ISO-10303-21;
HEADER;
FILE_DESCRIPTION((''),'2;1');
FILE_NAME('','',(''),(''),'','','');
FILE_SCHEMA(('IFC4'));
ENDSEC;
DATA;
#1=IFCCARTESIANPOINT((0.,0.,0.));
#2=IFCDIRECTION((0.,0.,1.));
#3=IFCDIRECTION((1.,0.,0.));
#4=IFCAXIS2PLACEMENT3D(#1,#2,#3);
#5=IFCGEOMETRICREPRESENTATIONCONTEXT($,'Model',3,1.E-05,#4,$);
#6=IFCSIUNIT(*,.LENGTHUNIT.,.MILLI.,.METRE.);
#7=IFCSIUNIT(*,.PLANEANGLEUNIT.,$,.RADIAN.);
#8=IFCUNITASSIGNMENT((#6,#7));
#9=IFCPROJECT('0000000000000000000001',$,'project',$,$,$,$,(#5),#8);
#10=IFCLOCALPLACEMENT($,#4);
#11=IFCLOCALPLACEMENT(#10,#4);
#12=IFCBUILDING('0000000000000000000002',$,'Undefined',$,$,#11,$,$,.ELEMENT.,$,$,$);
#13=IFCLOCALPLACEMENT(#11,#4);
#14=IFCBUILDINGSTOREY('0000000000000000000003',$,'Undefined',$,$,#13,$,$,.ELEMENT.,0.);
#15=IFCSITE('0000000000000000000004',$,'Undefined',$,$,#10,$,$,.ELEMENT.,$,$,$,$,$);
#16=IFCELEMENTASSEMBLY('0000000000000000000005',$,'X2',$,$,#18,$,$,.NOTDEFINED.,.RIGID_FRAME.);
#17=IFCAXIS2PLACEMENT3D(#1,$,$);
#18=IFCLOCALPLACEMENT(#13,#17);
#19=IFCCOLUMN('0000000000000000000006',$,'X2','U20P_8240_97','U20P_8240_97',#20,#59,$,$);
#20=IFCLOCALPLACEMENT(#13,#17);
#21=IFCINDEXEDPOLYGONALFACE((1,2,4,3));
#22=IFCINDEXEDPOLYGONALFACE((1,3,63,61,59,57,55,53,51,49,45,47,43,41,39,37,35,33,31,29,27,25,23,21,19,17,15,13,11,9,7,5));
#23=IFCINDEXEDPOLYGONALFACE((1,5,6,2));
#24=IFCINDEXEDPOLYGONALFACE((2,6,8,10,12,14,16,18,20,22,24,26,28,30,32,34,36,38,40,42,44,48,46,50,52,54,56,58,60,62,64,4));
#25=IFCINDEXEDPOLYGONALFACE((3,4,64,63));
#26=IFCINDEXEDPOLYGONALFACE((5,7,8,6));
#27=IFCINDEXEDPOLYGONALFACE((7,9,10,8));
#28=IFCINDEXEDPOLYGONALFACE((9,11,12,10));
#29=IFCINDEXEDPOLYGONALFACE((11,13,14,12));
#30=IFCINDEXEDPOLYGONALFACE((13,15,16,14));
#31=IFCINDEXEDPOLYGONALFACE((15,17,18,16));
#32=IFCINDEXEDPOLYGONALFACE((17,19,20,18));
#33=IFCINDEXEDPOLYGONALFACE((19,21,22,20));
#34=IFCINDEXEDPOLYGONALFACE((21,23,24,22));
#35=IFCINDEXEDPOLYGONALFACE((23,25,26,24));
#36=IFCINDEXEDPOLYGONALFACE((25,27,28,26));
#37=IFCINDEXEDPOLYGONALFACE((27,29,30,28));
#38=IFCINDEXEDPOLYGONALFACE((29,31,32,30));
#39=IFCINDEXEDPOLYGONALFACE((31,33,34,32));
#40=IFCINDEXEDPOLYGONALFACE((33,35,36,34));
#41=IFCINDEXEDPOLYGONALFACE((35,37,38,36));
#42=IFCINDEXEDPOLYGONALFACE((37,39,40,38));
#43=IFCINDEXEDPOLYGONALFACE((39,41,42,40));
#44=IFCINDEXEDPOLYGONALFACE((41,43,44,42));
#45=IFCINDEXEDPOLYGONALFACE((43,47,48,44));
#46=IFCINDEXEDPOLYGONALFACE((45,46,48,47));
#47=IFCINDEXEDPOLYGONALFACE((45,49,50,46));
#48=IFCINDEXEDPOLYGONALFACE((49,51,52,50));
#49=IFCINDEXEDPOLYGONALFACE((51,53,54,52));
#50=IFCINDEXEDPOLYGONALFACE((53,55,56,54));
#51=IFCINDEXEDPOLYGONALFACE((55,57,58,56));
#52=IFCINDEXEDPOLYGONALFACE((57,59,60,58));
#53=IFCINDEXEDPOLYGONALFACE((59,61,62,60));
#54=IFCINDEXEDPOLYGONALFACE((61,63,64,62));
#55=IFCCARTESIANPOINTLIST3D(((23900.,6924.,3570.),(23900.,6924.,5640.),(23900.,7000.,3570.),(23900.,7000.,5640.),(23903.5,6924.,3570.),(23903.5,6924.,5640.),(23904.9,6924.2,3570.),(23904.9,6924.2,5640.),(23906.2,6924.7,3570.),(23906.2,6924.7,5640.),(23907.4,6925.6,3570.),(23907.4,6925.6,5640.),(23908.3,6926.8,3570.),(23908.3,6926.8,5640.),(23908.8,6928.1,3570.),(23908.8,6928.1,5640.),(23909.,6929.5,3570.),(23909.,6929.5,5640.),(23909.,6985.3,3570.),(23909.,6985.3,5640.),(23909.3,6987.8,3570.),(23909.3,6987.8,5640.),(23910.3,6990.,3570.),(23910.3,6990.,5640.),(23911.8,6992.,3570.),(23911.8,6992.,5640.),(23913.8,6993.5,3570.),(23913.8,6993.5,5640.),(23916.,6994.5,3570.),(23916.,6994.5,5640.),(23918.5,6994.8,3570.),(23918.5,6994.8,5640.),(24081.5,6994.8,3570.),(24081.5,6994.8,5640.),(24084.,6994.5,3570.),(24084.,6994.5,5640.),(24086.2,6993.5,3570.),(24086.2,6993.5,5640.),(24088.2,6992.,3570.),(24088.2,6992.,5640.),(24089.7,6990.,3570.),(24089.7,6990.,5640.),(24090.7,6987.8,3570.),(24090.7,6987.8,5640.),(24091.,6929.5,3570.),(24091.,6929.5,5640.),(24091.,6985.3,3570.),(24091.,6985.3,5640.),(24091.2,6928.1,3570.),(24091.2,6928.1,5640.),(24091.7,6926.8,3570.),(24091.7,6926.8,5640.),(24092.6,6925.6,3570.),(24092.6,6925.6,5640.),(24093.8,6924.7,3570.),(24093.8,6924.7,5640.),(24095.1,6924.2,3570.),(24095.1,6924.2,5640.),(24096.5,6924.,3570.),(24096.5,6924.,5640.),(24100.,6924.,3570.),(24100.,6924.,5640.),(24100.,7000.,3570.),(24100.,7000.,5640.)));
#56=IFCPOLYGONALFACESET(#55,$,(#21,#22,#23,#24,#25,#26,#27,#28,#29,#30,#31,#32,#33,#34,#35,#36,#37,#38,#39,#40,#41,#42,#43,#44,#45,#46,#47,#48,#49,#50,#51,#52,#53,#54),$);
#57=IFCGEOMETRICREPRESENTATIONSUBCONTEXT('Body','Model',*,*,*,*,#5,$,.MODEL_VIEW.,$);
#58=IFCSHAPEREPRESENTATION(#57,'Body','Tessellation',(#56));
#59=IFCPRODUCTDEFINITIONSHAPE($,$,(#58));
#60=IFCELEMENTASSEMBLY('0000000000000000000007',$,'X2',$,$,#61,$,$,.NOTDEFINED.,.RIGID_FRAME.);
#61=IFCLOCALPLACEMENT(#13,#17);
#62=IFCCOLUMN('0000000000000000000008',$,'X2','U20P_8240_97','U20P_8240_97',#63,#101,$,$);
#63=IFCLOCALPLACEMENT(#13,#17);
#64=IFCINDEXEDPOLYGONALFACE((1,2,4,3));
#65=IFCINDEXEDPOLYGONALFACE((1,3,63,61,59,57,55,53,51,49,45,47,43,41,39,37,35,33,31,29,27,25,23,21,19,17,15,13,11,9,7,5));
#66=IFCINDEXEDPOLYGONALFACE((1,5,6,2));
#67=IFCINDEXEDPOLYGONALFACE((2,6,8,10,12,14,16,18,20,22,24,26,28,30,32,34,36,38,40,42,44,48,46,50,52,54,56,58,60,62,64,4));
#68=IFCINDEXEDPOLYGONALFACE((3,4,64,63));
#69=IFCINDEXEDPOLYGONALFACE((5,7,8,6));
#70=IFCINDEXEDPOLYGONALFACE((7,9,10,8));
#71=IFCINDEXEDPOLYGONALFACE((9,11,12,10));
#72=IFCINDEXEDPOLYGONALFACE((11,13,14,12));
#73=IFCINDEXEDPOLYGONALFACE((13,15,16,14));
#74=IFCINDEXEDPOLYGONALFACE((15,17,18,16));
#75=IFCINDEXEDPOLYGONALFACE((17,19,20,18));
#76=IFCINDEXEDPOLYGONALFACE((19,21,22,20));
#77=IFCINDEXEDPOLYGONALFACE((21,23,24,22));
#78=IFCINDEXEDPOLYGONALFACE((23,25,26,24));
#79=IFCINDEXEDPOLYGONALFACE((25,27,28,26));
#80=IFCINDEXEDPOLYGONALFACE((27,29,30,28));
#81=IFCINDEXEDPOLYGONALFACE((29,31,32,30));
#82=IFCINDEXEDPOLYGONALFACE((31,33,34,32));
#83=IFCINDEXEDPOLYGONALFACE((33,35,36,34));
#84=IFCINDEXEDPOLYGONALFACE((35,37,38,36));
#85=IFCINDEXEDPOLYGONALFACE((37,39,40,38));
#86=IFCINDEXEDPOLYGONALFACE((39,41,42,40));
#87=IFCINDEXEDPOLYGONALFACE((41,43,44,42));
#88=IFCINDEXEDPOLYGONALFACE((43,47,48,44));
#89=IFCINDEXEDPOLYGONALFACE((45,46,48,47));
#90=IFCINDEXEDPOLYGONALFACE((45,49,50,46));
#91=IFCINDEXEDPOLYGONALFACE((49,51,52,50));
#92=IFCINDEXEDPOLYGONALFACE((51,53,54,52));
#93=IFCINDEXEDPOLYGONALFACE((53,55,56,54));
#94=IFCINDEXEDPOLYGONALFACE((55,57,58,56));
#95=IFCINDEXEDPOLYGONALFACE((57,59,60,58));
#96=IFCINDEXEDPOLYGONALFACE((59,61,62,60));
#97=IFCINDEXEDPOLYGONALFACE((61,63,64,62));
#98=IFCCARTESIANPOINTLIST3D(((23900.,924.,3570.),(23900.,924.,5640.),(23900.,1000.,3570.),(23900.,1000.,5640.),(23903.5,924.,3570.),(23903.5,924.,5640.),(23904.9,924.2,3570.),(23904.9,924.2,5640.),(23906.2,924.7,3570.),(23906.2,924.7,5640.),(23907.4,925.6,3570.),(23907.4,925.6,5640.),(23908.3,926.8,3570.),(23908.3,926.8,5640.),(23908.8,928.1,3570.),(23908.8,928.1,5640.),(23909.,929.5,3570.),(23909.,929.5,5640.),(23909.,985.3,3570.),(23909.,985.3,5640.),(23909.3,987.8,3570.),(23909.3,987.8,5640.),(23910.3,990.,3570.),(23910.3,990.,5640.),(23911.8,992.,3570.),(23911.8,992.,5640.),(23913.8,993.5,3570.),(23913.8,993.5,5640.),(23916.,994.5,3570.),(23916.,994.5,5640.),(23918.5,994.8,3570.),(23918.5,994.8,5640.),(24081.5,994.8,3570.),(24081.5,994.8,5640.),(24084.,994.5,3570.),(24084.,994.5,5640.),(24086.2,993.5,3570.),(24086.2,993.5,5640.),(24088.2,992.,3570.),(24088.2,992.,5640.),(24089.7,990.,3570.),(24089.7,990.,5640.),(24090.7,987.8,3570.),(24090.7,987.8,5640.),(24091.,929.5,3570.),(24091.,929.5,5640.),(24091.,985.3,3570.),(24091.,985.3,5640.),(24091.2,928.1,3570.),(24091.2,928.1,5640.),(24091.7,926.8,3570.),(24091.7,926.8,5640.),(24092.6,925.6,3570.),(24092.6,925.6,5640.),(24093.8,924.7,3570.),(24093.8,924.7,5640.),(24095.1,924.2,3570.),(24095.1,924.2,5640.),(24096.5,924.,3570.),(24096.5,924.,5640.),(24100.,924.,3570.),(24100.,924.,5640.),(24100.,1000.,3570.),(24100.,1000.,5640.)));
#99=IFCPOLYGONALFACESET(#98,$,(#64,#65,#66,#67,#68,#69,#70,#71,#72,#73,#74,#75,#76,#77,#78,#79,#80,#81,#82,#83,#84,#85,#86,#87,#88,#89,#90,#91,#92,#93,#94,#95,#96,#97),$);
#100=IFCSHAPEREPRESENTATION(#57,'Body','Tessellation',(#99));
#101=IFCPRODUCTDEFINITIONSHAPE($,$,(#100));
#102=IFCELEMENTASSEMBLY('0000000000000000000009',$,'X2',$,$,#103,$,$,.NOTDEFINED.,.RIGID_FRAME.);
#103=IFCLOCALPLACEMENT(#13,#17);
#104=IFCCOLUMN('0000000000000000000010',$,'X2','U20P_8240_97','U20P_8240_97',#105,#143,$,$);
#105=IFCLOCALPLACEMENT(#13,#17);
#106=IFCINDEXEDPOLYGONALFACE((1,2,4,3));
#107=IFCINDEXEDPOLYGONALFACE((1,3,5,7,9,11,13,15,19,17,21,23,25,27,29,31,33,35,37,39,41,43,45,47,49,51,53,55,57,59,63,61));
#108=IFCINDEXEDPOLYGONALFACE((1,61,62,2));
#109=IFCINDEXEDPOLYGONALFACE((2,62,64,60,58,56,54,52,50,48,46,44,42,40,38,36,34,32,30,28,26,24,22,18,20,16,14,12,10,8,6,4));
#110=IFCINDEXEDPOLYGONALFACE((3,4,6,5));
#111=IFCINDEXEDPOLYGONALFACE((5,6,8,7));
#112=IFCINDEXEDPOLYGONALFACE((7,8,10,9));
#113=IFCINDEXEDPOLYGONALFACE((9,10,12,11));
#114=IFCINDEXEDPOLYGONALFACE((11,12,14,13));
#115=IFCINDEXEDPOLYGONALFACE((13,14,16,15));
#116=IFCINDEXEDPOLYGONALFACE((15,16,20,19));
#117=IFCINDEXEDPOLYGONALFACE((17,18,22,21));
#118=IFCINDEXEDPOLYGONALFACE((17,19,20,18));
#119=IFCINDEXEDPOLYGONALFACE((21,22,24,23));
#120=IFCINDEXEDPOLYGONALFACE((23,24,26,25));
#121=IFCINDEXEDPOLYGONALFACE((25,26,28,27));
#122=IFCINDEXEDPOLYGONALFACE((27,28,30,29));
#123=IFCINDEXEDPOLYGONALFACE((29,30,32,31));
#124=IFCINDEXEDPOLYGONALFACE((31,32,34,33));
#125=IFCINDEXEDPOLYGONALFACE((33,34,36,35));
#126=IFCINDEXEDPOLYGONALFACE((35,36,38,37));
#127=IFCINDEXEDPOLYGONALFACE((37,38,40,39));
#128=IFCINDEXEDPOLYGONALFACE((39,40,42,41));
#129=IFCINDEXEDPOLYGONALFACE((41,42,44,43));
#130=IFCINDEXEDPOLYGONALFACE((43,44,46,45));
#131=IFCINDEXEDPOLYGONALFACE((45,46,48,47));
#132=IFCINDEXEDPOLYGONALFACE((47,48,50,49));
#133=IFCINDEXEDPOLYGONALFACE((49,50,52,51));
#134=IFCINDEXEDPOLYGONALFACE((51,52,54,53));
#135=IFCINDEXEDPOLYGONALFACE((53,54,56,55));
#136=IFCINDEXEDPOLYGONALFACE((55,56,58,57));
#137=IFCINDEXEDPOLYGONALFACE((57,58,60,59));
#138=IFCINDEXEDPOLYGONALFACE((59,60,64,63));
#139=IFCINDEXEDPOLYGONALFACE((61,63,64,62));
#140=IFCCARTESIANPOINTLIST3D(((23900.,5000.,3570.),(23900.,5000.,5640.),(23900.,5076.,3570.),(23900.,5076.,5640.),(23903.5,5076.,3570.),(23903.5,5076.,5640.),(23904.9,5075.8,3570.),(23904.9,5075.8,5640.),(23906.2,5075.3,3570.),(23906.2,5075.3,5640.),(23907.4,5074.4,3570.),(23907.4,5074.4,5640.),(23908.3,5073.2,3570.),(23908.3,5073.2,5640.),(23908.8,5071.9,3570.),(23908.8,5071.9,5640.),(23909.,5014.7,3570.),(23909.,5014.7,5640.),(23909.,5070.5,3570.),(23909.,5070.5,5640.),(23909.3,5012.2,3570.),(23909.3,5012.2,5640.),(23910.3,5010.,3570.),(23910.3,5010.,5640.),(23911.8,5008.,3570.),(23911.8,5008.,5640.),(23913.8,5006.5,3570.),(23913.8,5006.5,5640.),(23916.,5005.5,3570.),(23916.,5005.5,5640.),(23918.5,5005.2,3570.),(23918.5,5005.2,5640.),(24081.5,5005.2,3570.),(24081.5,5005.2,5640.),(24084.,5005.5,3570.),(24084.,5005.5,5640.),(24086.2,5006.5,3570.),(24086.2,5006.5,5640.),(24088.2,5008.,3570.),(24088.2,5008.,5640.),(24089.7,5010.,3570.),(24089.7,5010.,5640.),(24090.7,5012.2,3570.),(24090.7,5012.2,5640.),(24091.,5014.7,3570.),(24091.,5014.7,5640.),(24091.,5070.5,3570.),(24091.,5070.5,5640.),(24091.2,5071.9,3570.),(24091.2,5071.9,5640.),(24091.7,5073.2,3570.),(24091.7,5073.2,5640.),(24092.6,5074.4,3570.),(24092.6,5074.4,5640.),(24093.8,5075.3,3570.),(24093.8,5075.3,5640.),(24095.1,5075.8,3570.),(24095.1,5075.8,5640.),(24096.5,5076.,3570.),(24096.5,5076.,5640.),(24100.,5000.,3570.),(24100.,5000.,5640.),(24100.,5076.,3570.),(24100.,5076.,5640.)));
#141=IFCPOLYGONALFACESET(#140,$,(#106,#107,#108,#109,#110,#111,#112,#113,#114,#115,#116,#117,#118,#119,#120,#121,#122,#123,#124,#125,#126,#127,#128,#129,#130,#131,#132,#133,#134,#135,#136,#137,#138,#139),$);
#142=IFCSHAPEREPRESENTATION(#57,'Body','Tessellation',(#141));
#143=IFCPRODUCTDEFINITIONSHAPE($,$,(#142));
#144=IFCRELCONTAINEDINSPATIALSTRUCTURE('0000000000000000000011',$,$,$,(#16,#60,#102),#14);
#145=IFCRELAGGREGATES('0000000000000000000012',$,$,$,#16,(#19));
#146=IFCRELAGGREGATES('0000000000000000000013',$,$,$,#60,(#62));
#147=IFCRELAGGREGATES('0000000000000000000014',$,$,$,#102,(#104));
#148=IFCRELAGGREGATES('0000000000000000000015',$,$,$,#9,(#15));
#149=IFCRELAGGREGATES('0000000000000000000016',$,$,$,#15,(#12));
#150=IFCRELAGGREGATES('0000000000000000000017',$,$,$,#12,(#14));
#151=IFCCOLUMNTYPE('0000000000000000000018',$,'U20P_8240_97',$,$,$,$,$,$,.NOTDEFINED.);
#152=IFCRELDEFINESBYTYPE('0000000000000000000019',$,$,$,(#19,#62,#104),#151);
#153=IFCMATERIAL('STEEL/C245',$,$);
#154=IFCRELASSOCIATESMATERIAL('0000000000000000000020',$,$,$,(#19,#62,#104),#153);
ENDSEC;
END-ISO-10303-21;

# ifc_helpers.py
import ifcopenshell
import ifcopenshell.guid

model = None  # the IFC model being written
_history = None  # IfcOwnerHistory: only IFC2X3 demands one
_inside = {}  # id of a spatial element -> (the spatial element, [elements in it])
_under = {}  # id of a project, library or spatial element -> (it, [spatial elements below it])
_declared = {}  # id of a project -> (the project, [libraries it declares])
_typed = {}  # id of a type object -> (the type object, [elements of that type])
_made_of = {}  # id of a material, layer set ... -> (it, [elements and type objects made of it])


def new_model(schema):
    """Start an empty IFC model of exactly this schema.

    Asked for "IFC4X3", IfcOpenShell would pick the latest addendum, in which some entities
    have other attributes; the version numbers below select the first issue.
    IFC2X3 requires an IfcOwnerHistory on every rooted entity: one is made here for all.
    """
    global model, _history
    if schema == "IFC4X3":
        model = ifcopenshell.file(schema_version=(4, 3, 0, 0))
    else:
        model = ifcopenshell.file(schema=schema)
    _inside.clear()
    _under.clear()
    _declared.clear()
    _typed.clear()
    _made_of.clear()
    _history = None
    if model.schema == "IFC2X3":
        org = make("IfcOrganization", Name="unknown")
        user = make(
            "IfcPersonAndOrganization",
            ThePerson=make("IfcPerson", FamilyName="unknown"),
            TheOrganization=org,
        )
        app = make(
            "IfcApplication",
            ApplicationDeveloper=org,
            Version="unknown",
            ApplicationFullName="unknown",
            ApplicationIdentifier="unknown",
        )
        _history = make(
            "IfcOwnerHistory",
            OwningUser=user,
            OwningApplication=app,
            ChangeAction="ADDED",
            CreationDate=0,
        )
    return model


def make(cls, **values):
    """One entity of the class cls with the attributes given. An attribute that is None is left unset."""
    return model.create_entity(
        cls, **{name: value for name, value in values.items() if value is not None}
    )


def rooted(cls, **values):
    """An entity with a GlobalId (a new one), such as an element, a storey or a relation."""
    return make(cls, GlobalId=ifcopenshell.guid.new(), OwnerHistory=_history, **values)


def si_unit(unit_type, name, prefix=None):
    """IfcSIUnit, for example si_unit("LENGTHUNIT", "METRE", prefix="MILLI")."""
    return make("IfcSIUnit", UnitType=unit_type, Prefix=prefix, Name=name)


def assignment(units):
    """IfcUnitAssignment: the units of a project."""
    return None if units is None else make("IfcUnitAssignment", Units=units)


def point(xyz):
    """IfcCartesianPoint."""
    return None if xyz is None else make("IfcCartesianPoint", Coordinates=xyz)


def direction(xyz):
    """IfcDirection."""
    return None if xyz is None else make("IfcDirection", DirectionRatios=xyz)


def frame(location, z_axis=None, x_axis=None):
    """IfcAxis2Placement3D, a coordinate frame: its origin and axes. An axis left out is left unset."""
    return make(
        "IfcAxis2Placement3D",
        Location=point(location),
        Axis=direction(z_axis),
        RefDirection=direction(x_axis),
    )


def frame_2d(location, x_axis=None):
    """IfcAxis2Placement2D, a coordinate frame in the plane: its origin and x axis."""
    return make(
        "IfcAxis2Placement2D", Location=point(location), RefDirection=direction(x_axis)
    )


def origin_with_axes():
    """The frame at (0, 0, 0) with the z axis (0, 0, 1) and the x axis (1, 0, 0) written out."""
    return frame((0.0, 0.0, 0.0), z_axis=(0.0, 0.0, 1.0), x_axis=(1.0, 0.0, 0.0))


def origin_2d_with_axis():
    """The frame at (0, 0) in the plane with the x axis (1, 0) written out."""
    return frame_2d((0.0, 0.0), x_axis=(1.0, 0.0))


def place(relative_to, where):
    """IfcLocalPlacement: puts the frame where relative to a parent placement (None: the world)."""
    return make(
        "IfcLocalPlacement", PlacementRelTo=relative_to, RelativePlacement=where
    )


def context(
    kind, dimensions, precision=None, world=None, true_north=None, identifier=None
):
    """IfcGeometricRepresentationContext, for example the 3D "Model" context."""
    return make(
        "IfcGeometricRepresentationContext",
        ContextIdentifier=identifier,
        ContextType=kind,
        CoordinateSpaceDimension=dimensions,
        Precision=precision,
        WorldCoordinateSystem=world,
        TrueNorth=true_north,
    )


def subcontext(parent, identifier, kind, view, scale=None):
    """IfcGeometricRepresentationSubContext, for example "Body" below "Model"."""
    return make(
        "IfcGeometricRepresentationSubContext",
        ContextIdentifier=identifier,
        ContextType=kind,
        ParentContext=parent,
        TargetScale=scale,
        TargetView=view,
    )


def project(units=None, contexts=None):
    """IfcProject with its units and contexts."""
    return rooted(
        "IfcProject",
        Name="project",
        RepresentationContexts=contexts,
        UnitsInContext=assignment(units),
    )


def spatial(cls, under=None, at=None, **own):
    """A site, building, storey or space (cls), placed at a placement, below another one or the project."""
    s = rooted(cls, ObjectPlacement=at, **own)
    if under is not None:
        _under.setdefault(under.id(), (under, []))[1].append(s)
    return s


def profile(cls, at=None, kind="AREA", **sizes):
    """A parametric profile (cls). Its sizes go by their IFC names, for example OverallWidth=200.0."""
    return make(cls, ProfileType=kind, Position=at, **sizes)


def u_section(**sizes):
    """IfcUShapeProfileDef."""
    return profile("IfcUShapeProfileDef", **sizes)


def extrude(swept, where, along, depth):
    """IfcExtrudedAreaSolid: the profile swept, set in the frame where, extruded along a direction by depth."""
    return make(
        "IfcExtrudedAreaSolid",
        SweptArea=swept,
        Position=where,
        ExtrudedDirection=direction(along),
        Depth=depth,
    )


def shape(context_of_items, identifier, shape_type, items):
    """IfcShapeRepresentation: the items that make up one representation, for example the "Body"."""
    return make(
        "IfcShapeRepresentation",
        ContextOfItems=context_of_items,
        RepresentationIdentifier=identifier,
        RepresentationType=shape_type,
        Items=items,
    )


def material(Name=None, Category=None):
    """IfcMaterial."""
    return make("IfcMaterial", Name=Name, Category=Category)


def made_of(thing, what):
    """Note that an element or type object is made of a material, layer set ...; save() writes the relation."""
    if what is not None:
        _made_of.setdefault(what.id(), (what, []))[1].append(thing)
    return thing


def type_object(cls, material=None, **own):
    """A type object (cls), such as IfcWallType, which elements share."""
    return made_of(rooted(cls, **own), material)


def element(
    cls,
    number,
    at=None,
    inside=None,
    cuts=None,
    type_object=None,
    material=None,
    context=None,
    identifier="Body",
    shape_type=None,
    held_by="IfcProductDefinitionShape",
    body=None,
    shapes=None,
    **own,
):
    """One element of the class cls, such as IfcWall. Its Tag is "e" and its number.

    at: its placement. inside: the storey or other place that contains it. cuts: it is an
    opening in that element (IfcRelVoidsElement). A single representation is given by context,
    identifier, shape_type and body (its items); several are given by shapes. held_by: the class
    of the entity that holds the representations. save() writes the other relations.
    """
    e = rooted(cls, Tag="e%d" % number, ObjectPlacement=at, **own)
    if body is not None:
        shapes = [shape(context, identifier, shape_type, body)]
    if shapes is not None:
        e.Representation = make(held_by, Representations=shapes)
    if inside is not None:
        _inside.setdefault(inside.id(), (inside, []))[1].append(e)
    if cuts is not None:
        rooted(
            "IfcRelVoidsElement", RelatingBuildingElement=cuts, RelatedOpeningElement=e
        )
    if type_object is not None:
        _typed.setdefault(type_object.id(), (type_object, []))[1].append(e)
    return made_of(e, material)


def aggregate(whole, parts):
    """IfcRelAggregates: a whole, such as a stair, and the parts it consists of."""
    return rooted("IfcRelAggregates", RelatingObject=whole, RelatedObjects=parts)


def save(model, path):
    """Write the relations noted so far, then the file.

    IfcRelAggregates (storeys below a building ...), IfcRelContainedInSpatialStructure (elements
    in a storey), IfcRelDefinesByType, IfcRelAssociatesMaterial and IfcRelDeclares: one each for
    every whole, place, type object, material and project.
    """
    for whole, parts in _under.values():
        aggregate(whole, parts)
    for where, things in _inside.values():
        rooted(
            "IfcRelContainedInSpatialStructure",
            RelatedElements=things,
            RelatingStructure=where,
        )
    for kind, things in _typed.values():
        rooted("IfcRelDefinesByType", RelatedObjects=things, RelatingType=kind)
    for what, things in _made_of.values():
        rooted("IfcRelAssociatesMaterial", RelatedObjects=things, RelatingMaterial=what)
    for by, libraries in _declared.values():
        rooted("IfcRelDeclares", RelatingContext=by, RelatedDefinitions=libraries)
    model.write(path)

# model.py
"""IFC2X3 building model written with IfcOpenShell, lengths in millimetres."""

from ifc_helpers import new_model, si_unit, frame, origin_with_axes, origin_2d_with_axis, place, context, subcontext, project, spatial, u_section, extrude, material, type_object, element, aggregate, save


model = new_model("IFC2X3")

# Units and contexts
model_context = context("Model", 3, precision=1e-05, world=origin_with_axes())
body_context = subcontext(model_context, "Body", "Model", "MODEL_VIEW")
ifc_project = project(units=[si_unit("LENGTHUNIT", "METRE", prefix="MILLI"), si_unit("PLANEANGLEUNIT", "RADIAN")], contexts=[model_context])

# Site, building, storey
site_placement = place(None, origin_with_axes())
site = spatial("IfcSite", under=ifc_project, at=site_placement, Name="Undefined", CompositionType="ELEMENT")
building_placement = place(site_placement, origin_with_axes())
building = spatial("IfcBuilding", under=site, at=building_placement, Name="Undefined", CompositionType="ELEMENT")
storey_placement = place(building_placement, origin_with_axes())
storey = spatial("IfcBuildingStorey", under=building, at=storey_placement, Name="Undefined", CompositionType="ELEMENT", Elevation=0.0)

# Element assemblies, columns
assembly_1_placement = place(storey_placement, origin_with_axes())
assembly_1 = element("IfcElementAssembly", 1, at=assembly_1_placement, inside=storey, Name="X2", AssemblyPlace="NOTDEFINED", PredefinedType="RIGID_FRAME")
ifc_material_1 = material(Name="STEEL/C245")
column_type = type_object("IfcColumnType", Name="U20P_8240_97", PredefinedType="NOTDEFINED")
column_1_placement = place(assembly_1_placement, frame((24000.0, 6962.0, 3570.0), z_axis=(0.0, 0.0, 1.0), x_axis=(-1.0, 0.0, 0.0)))
column_1 = element("IfcColumn", 2, at=column_1_placement, type_object=column_type, material=ifc_material_1, Name="X2", Description="U20P_8240_97", ObjectType="U20P_8240_97", context=body_context, shape_type="SweptSolid", body=[
    extrude(u_section(Depth=200.0, FlangeWidth=76.0, WebThickness=5.2, FlangeThickness=9.0, FilletRadius=9.5, EdgeRadius=5.5, at=origin_2d_with_axis()), frame((0.0, 0.0, 2070.0), z_axis=(0.0, 0.0, -1.0), x_axis=(0.0, 1.0, 0.0)), (0.0, 0.0, 1.0), 2070.0),
])
aggregate(assembly_1, [column_1])
assembly_2_placement = place(storey_placement, origin_with_axes())
assembly_2 = element("IfcElementAssembly", 3, at=assembly_2_placement, inside=storey, Name="X2", AssemblyPlace="NOTDEFINED", PredefinedType="RIGID_FRAME")
column_2_placement = place(assembly_2_placement, frame((24000.0, 962.0, 3570.0), z_axis=(0.0, 0.0, 1.0), x_axis=(-1.0, 0.0, 0.0)))
column_2 = element("IfcColumn", 4, at=column_2_placement, type_object=column_type, material=ifc_material_1, Name="X2", Description="U20P_8240_97", ObjectType="U20P_8240_97", context=body_context, shape_type="SweptSolid", body=[
    extrude(u_section(Depth=200.0, FlangeWidth=76.0, WebThickness=5.2, FlangeThickness=9.0, FilletRadius=9.5, EdgeRadius=5.5, at=origin_2d_with_axis()), frame((0.0, 0.0, 2070.0), z_axis=(0.0, 0.0, -1.0), x_axis=(0.0, 1.0, 0.0)), (0.0, 0.0, 1.0), 2070.0),
])
aggregate(assembly_2, [column_2])
assembly_3_placement = place(storey_placement, origin_with_axes())
assembly_3 = element("IfcElementAssembly", 5, at=assembly_3_placement, inside=storey, Name="X2", AssemblyPlace="NOTDEFINED", PredefinedType="RIGID_FRAME")
column_3_placement = place(assembly_3_placement, frame((24000.0, 5038.0, 3570.0), z_axis=(0.0, 0.0, 1.0), x_axis=(1.0, 0.0, 0.0)))
column_3 = element("IfcColumn", 6, at=column_3_placement, type_object=column_type, material=ifc_material_1, Name="X2", Description="U20P_8240_97", ObjectType="U20P_8240_97", context=body_context, shape_type="SweptSolid", body=[
    extrude(u_section(Depth=200.0, FlangeWidth=76.0, WebThickness=5.2, FlangeThickness=9.0, FilletRadius=9.5, EdgeRadius=5.5, at=origin_2d_with_axis()), frame((0.0, 0.0, 2070.0), z_axis=(0.0, 0.0, -1.0), x_axis=(0.0, 1.0, 0.0)), (0.0, 0.0, 1.0), 2070.0),
])
aggregate(assembly_3, [column_3])

save(model, "model.ifc")
